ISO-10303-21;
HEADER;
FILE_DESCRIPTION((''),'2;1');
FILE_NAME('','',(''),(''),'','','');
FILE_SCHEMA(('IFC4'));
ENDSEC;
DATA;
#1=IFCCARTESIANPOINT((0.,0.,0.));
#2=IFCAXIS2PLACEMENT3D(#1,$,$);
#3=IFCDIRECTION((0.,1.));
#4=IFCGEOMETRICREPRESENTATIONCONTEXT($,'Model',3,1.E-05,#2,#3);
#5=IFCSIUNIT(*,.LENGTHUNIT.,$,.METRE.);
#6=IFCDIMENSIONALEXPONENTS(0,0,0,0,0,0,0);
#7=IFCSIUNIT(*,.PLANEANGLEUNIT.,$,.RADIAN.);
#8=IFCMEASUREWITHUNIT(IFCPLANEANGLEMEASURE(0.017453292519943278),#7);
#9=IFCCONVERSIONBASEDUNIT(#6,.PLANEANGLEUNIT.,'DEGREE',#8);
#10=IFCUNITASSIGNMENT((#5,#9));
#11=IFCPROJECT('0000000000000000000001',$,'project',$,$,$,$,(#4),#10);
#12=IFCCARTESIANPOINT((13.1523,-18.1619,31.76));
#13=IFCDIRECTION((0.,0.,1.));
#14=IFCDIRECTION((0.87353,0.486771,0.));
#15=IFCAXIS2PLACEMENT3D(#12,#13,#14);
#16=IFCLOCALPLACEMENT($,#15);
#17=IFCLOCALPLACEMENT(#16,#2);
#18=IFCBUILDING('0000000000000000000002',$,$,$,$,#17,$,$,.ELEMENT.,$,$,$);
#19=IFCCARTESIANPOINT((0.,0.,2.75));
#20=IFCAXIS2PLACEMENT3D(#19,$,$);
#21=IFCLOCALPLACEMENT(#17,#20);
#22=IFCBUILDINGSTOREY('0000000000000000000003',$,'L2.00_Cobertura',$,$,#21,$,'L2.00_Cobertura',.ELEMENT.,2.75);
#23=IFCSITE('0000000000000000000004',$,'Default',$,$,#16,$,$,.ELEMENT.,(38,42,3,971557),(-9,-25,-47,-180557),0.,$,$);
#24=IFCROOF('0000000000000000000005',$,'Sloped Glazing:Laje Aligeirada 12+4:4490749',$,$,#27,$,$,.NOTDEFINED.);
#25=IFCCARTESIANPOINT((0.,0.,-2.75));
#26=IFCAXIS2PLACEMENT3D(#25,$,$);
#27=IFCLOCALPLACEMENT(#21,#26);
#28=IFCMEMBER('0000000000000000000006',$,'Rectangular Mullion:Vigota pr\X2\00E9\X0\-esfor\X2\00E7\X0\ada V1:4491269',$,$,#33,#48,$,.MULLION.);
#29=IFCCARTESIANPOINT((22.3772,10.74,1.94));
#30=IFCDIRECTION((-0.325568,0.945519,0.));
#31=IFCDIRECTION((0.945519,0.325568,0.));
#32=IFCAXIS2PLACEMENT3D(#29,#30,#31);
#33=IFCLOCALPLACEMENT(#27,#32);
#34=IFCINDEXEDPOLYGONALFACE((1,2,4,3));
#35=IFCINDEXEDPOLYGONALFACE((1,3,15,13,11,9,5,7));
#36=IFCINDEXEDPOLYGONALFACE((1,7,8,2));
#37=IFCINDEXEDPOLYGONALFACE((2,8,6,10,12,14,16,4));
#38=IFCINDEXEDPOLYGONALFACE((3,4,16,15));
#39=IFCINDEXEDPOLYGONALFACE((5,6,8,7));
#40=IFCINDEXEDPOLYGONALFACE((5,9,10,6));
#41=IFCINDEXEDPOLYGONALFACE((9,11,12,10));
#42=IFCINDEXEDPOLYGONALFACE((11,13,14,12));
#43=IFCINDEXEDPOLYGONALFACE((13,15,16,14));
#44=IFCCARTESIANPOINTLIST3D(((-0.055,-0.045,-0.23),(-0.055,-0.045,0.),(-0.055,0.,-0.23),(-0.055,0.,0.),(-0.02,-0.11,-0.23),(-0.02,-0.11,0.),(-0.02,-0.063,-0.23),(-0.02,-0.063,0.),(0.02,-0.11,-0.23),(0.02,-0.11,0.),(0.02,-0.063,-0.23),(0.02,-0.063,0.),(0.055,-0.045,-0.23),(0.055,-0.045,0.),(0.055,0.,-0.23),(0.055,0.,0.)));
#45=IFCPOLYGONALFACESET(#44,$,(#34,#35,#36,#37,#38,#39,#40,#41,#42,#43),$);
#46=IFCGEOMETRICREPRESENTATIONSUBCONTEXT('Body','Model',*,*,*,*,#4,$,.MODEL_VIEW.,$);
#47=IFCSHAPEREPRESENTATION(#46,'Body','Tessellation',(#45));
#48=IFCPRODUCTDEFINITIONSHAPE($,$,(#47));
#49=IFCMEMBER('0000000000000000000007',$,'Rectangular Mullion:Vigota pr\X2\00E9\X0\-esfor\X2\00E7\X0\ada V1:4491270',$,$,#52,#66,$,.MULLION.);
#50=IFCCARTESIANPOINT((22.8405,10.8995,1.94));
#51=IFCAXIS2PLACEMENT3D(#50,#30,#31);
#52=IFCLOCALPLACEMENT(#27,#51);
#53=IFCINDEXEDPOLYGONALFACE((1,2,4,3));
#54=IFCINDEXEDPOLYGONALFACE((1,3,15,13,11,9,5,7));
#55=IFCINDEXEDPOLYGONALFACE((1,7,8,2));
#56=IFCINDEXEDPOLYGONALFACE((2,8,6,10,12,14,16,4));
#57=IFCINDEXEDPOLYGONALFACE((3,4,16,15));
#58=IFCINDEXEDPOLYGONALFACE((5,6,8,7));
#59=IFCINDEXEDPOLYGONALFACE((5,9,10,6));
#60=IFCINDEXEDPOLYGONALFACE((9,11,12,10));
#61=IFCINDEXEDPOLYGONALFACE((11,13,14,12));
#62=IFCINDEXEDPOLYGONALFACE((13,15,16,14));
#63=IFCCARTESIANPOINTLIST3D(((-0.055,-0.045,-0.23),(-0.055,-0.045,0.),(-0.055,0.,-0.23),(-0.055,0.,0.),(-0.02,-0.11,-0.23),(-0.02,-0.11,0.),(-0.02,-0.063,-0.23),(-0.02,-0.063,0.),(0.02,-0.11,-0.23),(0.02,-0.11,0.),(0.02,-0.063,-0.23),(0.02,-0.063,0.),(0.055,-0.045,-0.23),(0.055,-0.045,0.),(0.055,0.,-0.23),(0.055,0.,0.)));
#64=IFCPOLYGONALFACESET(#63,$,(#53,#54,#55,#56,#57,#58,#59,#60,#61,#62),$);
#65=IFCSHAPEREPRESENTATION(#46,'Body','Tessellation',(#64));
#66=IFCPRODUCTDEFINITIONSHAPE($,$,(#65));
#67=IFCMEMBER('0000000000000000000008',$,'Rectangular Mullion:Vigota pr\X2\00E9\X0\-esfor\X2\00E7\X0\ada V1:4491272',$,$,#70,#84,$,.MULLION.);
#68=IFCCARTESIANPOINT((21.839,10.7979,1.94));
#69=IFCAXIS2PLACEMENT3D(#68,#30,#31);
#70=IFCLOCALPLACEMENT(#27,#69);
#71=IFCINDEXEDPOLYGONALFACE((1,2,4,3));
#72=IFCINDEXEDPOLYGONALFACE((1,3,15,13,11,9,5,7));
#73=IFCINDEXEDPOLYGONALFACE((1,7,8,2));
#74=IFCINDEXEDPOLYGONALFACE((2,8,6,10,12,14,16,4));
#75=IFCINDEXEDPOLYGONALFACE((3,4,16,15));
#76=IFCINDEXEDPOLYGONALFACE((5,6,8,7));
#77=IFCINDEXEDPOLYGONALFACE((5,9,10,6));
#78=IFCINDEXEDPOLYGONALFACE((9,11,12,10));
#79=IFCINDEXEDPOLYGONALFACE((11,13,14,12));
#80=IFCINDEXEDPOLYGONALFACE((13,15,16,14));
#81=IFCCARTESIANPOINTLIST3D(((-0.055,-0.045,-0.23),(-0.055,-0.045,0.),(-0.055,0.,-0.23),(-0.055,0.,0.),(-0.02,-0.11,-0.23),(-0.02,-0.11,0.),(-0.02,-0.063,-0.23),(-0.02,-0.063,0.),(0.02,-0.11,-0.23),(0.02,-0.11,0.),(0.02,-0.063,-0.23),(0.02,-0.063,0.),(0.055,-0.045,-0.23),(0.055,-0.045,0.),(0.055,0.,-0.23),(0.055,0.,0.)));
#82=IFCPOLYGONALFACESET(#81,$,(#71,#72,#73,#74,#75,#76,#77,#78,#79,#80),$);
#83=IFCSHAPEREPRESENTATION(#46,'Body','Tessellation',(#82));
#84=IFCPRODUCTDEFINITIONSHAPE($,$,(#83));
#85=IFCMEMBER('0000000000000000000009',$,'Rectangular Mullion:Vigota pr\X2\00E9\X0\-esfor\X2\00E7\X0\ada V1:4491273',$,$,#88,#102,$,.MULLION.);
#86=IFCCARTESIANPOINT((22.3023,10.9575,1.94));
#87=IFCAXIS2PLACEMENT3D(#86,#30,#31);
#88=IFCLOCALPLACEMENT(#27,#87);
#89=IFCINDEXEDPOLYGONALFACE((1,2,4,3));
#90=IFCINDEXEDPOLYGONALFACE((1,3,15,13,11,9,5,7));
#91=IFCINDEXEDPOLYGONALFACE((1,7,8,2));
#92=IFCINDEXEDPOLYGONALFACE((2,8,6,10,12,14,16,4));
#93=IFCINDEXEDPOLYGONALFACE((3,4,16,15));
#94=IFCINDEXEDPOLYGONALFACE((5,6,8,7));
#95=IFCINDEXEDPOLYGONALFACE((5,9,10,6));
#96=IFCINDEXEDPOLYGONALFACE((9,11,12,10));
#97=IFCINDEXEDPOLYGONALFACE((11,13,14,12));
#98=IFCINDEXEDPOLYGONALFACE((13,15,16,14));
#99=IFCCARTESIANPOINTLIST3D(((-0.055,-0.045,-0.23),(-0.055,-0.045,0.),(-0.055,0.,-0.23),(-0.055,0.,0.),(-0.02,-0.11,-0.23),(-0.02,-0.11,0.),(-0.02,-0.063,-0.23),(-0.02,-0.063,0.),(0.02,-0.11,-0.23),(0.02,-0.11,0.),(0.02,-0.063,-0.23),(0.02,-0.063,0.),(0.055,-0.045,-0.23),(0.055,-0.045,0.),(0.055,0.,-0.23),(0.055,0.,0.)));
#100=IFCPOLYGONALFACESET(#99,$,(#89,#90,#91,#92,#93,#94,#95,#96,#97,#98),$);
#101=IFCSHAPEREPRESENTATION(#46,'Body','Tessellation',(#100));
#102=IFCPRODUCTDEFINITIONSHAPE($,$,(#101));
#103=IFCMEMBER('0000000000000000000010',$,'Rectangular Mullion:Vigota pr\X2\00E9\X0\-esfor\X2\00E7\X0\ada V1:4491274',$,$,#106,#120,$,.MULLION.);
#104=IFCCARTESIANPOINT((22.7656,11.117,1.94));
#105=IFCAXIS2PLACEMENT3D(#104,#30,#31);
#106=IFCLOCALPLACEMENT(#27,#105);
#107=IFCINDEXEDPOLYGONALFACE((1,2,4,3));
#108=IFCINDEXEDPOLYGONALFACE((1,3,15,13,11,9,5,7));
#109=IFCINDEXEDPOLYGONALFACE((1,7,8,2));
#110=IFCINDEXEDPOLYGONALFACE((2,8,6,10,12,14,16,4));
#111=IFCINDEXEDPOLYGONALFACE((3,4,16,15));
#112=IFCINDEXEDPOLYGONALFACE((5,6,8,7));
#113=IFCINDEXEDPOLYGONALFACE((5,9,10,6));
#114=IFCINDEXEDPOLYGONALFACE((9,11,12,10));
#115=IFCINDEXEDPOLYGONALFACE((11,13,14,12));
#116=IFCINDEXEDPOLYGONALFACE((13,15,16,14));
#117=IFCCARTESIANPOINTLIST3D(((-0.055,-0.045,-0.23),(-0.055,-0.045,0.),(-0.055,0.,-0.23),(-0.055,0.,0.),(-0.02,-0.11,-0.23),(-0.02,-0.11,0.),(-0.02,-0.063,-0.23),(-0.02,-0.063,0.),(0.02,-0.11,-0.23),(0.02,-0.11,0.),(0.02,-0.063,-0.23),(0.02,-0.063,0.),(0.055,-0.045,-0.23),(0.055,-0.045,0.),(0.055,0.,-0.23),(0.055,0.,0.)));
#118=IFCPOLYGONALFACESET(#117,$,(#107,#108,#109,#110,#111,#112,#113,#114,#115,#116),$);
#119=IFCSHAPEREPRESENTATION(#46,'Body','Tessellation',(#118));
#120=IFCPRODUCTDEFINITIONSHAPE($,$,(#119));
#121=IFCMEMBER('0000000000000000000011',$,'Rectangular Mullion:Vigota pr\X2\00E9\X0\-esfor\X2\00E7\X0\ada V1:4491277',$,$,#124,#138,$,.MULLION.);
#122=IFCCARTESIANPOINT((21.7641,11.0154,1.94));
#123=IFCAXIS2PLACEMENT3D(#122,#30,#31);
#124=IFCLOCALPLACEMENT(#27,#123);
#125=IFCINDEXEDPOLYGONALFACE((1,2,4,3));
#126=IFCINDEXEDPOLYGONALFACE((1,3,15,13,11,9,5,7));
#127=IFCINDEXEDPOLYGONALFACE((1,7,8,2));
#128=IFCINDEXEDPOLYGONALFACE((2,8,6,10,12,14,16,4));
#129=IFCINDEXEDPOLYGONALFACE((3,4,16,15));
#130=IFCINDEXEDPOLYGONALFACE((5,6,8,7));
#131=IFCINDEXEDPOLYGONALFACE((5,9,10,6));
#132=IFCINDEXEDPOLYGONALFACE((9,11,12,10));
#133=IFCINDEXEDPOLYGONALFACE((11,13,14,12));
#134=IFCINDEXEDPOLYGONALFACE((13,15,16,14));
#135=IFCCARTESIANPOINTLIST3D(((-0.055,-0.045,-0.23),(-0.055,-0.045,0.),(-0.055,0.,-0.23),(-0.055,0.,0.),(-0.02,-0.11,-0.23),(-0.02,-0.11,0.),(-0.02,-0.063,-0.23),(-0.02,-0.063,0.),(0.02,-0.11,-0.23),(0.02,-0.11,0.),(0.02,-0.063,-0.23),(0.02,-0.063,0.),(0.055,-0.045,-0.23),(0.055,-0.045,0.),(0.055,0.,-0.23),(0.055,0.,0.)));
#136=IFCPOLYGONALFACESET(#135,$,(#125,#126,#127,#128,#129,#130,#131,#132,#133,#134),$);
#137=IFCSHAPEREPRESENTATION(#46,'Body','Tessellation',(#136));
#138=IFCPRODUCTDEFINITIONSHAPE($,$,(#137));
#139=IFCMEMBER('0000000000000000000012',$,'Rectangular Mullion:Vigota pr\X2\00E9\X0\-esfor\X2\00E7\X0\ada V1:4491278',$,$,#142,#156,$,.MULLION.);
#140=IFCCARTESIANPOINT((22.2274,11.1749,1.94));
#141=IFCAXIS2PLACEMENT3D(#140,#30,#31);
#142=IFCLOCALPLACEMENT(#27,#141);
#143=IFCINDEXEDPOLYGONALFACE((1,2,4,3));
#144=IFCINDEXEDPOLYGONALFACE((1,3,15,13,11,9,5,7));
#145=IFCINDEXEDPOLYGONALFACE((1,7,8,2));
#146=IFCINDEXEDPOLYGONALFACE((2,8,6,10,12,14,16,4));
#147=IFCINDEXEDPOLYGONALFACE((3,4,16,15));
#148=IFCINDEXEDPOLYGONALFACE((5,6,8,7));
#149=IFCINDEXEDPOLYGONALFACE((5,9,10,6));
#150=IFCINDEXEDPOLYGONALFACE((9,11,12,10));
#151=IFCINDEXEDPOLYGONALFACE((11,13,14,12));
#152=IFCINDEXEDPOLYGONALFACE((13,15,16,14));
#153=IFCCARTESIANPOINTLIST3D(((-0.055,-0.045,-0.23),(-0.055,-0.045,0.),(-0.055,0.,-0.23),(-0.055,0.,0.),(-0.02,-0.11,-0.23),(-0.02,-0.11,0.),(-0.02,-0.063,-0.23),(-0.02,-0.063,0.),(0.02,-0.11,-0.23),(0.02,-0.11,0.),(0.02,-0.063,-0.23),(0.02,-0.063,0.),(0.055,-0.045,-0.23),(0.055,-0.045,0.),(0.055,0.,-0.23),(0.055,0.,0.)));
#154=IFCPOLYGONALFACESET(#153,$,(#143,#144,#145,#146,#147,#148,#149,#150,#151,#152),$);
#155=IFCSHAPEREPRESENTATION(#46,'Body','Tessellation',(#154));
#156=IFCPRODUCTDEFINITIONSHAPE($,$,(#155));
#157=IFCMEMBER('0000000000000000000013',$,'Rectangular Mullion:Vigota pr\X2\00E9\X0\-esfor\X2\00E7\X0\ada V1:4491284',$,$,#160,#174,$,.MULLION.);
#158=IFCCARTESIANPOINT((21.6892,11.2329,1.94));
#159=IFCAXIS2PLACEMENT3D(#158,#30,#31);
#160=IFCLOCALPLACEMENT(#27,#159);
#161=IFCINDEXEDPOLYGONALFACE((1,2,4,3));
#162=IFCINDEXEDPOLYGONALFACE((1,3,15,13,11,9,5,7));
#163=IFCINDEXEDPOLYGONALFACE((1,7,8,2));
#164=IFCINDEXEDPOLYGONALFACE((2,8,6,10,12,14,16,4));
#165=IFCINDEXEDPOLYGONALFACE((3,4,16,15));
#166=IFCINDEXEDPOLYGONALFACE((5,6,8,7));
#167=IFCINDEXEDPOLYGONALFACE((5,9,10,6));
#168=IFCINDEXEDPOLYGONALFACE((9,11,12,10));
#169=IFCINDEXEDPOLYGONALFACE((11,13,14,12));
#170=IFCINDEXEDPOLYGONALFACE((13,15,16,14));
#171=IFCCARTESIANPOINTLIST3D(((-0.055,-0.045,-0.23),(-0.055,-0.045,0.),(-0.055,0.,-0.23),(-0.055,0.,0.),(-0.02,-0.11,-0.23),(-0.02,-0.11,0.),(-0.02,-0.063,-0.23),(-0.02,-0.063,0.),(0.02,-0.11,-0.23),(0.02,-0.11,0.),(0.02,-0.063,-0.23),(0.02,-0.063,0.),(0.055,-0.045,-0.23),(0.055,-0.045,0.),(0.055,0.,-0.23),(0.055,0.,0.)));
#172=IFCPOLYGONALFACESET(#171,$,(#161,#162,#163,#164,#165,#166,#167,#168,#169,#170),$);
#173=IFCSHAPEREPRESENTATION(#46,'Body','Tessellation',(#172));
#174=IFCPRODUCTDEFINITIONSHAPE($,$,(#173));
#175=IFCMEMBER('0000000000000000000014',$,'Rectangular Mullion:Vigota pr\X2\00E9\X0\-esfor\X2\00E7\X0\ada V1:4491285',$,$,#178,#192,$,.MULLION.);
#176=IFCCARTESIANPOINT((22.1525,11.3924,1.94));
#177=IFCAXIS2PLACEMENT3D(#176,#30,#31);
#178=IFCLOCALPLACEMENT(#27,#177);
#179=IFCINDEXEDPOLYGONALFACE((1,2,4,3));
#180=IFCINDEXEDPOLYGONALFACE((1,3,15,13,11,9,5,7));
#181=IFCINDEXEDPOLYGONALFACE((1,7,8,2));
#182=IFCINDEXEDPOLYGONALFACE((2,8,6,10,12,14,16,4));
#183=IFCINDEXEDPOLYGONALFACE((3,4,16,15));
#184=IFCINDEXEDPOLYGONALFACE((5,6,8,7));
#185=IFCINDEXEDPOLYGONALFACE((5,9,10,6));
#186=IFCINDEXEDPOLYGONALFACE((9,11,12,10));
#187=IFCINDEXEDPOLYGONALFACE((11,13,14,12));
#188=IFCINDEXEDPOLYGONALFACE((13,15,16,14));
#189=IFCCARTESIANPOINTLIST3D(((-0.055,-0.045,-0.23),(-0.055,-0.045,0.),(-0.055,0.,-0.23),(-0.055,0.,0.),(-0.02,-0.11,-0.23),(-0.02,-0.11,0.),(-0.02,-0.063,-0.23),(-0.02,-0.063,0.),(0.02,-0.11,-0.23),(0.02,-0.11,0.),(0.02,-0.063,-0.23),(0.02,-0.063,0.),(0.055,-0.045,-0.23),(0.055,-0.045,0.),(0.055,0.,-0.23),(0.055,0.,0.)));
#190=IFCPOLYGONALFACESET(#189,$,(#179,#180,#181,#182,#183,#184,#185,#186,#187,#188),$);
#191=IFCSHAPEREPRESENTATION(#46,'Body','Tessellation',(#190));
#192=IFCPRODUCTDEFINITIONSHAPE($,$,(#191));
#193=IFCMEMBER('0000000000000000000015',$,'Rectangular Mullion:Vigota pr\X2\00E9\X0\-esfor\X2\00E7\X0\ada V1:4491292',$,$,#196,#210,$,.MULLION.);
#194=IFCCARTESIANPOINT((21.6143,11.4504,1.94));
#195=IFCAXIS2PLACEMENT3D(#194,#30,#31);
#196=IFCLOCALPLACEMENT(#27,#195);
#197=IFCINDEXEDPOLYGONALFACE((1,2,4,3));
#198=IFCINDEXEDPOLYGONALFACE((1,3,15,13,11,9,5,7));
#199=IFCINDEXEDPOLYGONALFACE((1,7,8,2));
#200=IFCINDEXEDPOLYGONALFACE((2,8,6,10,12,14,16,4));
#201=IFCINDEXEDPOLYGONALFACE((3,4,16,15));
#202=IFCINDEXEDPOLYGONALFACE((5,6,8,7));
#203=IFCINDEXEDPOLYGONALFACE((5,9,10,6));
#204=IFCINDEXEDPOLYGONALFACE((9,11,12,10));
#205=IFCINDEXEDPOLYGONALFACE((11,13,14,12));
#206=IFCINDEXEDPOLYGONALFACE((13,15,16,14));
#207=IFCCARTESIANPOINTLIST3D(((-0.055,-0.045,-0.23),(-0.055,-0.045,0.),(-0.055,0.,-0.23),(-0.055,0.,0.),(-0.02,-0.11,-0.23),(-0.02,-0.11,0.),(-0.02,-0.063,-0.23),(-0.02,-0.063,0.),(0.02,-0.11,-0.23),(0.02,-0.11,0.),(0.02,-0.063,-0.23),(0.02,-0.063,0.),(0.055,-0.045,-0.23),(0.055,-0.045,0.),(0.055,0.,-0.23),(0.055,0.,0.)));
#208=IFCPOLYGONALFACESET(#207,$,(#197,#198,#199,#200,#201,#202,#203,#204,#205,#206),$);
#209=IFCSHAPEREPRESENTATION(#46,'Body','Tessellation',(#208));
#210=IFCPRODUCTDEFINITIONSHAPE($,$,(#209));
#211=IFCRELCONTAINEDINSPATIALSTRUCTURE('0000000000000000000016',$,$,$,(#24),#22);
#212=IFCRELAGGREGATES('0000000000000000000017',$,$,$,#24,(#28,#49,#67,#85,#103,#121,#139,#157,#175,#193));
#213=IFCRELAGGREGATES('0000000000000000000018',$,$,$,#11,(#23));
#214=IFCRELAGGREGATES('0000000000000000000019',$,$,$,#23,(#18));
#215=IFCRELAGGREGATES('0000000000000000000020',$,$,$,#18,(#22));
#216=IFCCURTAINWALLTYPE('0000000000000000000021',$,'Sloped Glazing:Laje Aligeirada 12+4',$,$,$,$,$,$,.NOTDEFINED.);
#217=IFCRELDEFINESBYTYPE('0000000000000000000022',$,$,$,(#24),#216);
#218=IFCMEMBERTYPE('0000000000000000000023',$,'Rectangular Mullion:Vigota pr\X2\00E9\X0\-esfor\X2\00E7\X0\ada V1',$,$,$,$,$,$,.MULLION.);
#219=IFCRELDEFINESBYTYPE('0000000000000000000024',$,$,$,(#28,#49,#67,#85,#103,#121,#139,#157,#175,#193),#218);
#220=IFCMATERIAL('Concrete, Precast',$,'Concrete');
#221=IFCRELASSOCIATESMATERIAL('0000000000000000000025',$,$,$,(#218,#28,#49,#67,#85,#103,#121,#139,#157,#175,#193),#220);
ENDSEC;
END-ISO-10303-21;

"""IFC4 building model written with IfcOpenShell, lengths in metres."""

from ifc_helpers import new_model, entity, si_unit, converted_unit, direction, frame, origin, place, context, subcontext, project, spatial, indexed_curve, outline, extrude, source, transform, mapped, material, type_object, type_shapes, element, aggregate, save


model = new_model("IFC4")

# Units and contexts
model_context = context("Model", 3, precision=1e-05, world=origin(), true_north=direction((0.0, 1.0)))
body_context = subcontext(model_context, "Body", "Model", "MODEL_VIEW")
ifc_project = project(units=[si_unit("LENGTHUNIT", "METRE"), converted_unit("PLANEANGLEUNIT", "DEGREE", entity("IfcPlaneAngleMeasure", 0.017453292519943278), si_unit("PLANEANGLEUNIT", "RADIAN"), dimensions=[0, 0, 0, 0, 0, 0, 0])], contexts=[model_context])

# Site, building, storey
site_placement = place(None, frame((13.1523, -18.1619, 31.76), z_axis=(0.0, 0.0, 1.0), x_axis=(0.87353, 0.486771, 0.0)))
site = spatial("IfcSite", under=ifc_project, at=site_placement, Name="Default", CompositionType="ELEMENT", RefLatitude=(38, 42, 3, 971557), RefLongitude=(-9, -25, -47, -180557), RefElevation=0.0)
building_placement = place(site_placement, origin())
building = spatial("IfcBuilding", under=site, at=building_placement, CompositionType="ELEMENT")
storey_placement = place(building_placement, frame((0.0, 0.0, 2.75)))
storey = spatial("IfcBuildingStorey", under=building, at=storey_placement, Name="L2.00_Cobertura", LongName="L2.00_Cobertura", CompositionType="ELEMENT", Elevation=2.75)

# Roof, members
curtain_wall_type = type_object("IfcCurtainWallType", Name="Sloped Glazing:Laje Aligeirada 12+4", PredefinedType="NOTDEFINED")
roof_placement = place(storey_placement, frame((0.0, 0.0, -2.75)))
roof = element("IfcRoof", 1, at=roof_placement, inside=storey, type_object=curtain_wall_type, Name="Sloped Glazing:Laje Aligeirada 12+4:4490749", PredefinedType="NOTDEFINED")
ifc_material_1 = material(Name="Concrete, Precast", Category="Concrete")
member_type_1 = type_object("IfcMemberType", Name="Rectangular Mullion:Vigota pré-esforçada V1", PredefinedType="MULLION", material=ifc_material_1)
shared_shape_1 = source(origin(), body_context, "Body", "SweptSolid", [
    extrude(outline(indexed_curve([(-0.055, -0.0545), (0.055, -0.0545), (0.055, -0.0095), (0.02, 0.0085), (0.02, 0.0555), (-0.02, 0.0555), (-0.02, 0.0085), (-0.055, -0.0095), (-0.055, -0.0545)], self_intersect=False)), frame((0.0, -0.0545, -0.23), z_axis=(0.0, 0.0, 1.0), x_axis=(-1.0, 0.0, 0.0)), (0.0, 0.0, 1.0), 0.23),
])
type_shapes(member_type_1, [shared_shape_1])
member_1_placement = place(roof_placement, frame((22.3772, 10.74, 1.94), z_axis=(-0.325568, 0.945519, 0.0), x_axis=(0.945519, 0.325568, 0.0)))
member_1 = element("IfcMember", 2, at=member_1_placement, type_object=member_type_1, material=ifc_material_1, Name="Rectangular Mullion:Vigota pré-esforçada V1:4491269", PredefinedType="MULLION", context=body_context, shape_type="MappedRepresentation", body=[
    mapped(shared_shape_1, transform((0.0, 0.0, 0.0), scale=1.0)),
])
member_2_placement = place(roof_placement, frame((22.8405, 10.8995, 1.94), z_axis=(-0.325568, 0.945519, 0.0), x_axis=(0.945519, 0.325568, 0.0)))
member_2 = element("IfcMember", 3, at=member_2_placement, type_object=member_type_1, material=ifc_material_1, Name="Rectangular Mullion:Vigota pré-esforçada V1:4491270", PredefinedType="MULLION", context=body_context, shape_type="MappedRepresentation", body=[
    mapped(shared_shape_1, transform((0.0, 0.0, 0.0), scale=1.0)),
])
member_3_placement = place(roof_placement, frame((21.839, 10.7979, 1.94), z_axis=(-0.325568, 0.945519, 0.0), x_axis=(0.945519, 0.325568, 0.0)))
member_3 = element("IfcMember", 4, at=member_3_placement, type_object=member_type_1, material=ifc_material_1, Name="Rectangular Mullion:Vigota pré-esforçada V1:4491272", PredefinedType="MULLION", context=body_context, shape_type="MappedRepresentation", body=[
    mapped(shared_shape_1, transform((0.0, 0.0, 0.0), scale=1.0)),
])
member_4_placement = place(roof_placement, frame((22.3023, 10.9575, 1.94), z_axis=(-0.325568, 0.945519, 0.0), x_axis=(0.945519, 0.325568, 0.0)))
member_4 = element("IfcMember", 5, at=member_4_placement, type_object=member_type_1, material=ifc_material_1, Name="Rectangular Mullion:Vigota pré-esforçada V1:4491273", PredefinedType="MULLION", context=body_context, shape_type="MappedRepresentation", body=[
    mapped(shared_shape_1, transform((0.0, 0.0, 0.0), scale=1.0)),
])
member_5_placement = place(roof_placement, frame((22.7656, 11.117, 1.94), z_axis=(-0.325568, 0.945519, 0.0), x_axis=(0.945519, 0.325568, 0.0)))
member_5 = element("IfcMember", 6, at=member_5_placement, type_object=member_type_1, material=ifc_material_1, Name="Rectangular Mullion:Vigota pré-esforçada V1:4491274", PredefinedType="MULLION", context=body_context, shape_type="MappedRepresentation", body=[
    mapped(shared_shape_1, transform((0.0, 0.0, 0.0), scale=1.0)),
])
member_6_placement = place(roof_placement, frame((21.7641, 11.0154, 1.94), z_axis=(-0.325568, 0.945519, 0.0), x_axis=(0.945519, 0.325568, 0.0)))
member_6 = element("IfcMember", 7, at=member_6_placement, type_object=member_type_1, material=ifc_material_1, Name="Rectangular Mullion:Vigota pré-esforçada V1:4491277", PredefinedType="MULLION", context=body_context, shape_type="MappedRepresentation", body=[
    mapped(shared_shape_1, transform((0.0, 0.0, 0.0), scale=1.0)),
])
member_7_placement = place(roof_placement, frame((22.2274, 11.1749, 1.94), z_axis=(-0.325568, 0.945519, 0.0), x_axis=(0.945519, 0.325568, 0.0)))
member_7 = element("IfcMember", 8, at=member_7_placement, type_object=member_type_1, material=ifc_material_1, Name="Rectangular Mullion:Vigota pré-esforçada V1:4491278", PredefinedType="MULLION", context=body_context, shape_type="MappedRepresentation", body=[
    mapped(shared_shape_1, transform((0.0, 0.0, 0.0), scale=1.0)),
])
member_8_placement = place(roof_placement, frame((21.6892, 11.2329, 1.94), z_axis=(-0.325568, 0.945519, 0.0), x_axis=(0.945519, 0.325568, 0.0)))
member_8 = element("IfcMember", 9, at=member_8_placement, type_object=member_type_1, material=ifc_material_1, Name="Rectangular Mullion:Vigota pré-esforçada V1:4491284", PredefinedType="MULLION", context=body_context, shape_type="MappedRepresentation", body=[
    mapped(shared_shape_1, transform((0.0, 0.0, 0.0), scale=1.0)),
])
member_9_placement = place(roof_placement, frame((22.1525, 11.3924, 1.94), z_axis=(-0.325568, 0.945519, 0.0), x_axis=(0.945519, 0.325568, 0.0)))
member_9 = element("IfcMember", 10, at=member_9_placement, type_object=member_type_1, material=ifc_material_1, Name="Rectangular Mullion:Vigota pré-esforçada V1:4491285", PredefinedType="MULLION", context=body_context, shape_type="MappedRepresentation", body=[
    mapped(shared_shape_1, transform((0.0, 0.0, 0.0), scale=1.0)),
])
member_10_placement = place(roof_placement, frame((21.6143, 11.4504, 1.94), z_axis=(-0.325568, 0.945519, 0.0), x_axis=(0.945519, 0.325568, 0.0)))
member_10 = element("IfcMember", 11, at=member_10_placement, type_object=member_type_1, material=ifc_material_1, Name="Rectangular Mullion:Vigota pré-esforçada V1:4491292", PredefinedType="MULLION", context=body_context, shape_type="MappedRepresentation", body=[
    mapped(shared_shape_1, transform((0.0, 0.0, 0.0), scale=1.0)),
])

aggregate(roof, [member_1, member_2, member_3, member_4, member_5, member_6, member_7, member_8, member_9, member_10])

save(model, "model.ifc")
